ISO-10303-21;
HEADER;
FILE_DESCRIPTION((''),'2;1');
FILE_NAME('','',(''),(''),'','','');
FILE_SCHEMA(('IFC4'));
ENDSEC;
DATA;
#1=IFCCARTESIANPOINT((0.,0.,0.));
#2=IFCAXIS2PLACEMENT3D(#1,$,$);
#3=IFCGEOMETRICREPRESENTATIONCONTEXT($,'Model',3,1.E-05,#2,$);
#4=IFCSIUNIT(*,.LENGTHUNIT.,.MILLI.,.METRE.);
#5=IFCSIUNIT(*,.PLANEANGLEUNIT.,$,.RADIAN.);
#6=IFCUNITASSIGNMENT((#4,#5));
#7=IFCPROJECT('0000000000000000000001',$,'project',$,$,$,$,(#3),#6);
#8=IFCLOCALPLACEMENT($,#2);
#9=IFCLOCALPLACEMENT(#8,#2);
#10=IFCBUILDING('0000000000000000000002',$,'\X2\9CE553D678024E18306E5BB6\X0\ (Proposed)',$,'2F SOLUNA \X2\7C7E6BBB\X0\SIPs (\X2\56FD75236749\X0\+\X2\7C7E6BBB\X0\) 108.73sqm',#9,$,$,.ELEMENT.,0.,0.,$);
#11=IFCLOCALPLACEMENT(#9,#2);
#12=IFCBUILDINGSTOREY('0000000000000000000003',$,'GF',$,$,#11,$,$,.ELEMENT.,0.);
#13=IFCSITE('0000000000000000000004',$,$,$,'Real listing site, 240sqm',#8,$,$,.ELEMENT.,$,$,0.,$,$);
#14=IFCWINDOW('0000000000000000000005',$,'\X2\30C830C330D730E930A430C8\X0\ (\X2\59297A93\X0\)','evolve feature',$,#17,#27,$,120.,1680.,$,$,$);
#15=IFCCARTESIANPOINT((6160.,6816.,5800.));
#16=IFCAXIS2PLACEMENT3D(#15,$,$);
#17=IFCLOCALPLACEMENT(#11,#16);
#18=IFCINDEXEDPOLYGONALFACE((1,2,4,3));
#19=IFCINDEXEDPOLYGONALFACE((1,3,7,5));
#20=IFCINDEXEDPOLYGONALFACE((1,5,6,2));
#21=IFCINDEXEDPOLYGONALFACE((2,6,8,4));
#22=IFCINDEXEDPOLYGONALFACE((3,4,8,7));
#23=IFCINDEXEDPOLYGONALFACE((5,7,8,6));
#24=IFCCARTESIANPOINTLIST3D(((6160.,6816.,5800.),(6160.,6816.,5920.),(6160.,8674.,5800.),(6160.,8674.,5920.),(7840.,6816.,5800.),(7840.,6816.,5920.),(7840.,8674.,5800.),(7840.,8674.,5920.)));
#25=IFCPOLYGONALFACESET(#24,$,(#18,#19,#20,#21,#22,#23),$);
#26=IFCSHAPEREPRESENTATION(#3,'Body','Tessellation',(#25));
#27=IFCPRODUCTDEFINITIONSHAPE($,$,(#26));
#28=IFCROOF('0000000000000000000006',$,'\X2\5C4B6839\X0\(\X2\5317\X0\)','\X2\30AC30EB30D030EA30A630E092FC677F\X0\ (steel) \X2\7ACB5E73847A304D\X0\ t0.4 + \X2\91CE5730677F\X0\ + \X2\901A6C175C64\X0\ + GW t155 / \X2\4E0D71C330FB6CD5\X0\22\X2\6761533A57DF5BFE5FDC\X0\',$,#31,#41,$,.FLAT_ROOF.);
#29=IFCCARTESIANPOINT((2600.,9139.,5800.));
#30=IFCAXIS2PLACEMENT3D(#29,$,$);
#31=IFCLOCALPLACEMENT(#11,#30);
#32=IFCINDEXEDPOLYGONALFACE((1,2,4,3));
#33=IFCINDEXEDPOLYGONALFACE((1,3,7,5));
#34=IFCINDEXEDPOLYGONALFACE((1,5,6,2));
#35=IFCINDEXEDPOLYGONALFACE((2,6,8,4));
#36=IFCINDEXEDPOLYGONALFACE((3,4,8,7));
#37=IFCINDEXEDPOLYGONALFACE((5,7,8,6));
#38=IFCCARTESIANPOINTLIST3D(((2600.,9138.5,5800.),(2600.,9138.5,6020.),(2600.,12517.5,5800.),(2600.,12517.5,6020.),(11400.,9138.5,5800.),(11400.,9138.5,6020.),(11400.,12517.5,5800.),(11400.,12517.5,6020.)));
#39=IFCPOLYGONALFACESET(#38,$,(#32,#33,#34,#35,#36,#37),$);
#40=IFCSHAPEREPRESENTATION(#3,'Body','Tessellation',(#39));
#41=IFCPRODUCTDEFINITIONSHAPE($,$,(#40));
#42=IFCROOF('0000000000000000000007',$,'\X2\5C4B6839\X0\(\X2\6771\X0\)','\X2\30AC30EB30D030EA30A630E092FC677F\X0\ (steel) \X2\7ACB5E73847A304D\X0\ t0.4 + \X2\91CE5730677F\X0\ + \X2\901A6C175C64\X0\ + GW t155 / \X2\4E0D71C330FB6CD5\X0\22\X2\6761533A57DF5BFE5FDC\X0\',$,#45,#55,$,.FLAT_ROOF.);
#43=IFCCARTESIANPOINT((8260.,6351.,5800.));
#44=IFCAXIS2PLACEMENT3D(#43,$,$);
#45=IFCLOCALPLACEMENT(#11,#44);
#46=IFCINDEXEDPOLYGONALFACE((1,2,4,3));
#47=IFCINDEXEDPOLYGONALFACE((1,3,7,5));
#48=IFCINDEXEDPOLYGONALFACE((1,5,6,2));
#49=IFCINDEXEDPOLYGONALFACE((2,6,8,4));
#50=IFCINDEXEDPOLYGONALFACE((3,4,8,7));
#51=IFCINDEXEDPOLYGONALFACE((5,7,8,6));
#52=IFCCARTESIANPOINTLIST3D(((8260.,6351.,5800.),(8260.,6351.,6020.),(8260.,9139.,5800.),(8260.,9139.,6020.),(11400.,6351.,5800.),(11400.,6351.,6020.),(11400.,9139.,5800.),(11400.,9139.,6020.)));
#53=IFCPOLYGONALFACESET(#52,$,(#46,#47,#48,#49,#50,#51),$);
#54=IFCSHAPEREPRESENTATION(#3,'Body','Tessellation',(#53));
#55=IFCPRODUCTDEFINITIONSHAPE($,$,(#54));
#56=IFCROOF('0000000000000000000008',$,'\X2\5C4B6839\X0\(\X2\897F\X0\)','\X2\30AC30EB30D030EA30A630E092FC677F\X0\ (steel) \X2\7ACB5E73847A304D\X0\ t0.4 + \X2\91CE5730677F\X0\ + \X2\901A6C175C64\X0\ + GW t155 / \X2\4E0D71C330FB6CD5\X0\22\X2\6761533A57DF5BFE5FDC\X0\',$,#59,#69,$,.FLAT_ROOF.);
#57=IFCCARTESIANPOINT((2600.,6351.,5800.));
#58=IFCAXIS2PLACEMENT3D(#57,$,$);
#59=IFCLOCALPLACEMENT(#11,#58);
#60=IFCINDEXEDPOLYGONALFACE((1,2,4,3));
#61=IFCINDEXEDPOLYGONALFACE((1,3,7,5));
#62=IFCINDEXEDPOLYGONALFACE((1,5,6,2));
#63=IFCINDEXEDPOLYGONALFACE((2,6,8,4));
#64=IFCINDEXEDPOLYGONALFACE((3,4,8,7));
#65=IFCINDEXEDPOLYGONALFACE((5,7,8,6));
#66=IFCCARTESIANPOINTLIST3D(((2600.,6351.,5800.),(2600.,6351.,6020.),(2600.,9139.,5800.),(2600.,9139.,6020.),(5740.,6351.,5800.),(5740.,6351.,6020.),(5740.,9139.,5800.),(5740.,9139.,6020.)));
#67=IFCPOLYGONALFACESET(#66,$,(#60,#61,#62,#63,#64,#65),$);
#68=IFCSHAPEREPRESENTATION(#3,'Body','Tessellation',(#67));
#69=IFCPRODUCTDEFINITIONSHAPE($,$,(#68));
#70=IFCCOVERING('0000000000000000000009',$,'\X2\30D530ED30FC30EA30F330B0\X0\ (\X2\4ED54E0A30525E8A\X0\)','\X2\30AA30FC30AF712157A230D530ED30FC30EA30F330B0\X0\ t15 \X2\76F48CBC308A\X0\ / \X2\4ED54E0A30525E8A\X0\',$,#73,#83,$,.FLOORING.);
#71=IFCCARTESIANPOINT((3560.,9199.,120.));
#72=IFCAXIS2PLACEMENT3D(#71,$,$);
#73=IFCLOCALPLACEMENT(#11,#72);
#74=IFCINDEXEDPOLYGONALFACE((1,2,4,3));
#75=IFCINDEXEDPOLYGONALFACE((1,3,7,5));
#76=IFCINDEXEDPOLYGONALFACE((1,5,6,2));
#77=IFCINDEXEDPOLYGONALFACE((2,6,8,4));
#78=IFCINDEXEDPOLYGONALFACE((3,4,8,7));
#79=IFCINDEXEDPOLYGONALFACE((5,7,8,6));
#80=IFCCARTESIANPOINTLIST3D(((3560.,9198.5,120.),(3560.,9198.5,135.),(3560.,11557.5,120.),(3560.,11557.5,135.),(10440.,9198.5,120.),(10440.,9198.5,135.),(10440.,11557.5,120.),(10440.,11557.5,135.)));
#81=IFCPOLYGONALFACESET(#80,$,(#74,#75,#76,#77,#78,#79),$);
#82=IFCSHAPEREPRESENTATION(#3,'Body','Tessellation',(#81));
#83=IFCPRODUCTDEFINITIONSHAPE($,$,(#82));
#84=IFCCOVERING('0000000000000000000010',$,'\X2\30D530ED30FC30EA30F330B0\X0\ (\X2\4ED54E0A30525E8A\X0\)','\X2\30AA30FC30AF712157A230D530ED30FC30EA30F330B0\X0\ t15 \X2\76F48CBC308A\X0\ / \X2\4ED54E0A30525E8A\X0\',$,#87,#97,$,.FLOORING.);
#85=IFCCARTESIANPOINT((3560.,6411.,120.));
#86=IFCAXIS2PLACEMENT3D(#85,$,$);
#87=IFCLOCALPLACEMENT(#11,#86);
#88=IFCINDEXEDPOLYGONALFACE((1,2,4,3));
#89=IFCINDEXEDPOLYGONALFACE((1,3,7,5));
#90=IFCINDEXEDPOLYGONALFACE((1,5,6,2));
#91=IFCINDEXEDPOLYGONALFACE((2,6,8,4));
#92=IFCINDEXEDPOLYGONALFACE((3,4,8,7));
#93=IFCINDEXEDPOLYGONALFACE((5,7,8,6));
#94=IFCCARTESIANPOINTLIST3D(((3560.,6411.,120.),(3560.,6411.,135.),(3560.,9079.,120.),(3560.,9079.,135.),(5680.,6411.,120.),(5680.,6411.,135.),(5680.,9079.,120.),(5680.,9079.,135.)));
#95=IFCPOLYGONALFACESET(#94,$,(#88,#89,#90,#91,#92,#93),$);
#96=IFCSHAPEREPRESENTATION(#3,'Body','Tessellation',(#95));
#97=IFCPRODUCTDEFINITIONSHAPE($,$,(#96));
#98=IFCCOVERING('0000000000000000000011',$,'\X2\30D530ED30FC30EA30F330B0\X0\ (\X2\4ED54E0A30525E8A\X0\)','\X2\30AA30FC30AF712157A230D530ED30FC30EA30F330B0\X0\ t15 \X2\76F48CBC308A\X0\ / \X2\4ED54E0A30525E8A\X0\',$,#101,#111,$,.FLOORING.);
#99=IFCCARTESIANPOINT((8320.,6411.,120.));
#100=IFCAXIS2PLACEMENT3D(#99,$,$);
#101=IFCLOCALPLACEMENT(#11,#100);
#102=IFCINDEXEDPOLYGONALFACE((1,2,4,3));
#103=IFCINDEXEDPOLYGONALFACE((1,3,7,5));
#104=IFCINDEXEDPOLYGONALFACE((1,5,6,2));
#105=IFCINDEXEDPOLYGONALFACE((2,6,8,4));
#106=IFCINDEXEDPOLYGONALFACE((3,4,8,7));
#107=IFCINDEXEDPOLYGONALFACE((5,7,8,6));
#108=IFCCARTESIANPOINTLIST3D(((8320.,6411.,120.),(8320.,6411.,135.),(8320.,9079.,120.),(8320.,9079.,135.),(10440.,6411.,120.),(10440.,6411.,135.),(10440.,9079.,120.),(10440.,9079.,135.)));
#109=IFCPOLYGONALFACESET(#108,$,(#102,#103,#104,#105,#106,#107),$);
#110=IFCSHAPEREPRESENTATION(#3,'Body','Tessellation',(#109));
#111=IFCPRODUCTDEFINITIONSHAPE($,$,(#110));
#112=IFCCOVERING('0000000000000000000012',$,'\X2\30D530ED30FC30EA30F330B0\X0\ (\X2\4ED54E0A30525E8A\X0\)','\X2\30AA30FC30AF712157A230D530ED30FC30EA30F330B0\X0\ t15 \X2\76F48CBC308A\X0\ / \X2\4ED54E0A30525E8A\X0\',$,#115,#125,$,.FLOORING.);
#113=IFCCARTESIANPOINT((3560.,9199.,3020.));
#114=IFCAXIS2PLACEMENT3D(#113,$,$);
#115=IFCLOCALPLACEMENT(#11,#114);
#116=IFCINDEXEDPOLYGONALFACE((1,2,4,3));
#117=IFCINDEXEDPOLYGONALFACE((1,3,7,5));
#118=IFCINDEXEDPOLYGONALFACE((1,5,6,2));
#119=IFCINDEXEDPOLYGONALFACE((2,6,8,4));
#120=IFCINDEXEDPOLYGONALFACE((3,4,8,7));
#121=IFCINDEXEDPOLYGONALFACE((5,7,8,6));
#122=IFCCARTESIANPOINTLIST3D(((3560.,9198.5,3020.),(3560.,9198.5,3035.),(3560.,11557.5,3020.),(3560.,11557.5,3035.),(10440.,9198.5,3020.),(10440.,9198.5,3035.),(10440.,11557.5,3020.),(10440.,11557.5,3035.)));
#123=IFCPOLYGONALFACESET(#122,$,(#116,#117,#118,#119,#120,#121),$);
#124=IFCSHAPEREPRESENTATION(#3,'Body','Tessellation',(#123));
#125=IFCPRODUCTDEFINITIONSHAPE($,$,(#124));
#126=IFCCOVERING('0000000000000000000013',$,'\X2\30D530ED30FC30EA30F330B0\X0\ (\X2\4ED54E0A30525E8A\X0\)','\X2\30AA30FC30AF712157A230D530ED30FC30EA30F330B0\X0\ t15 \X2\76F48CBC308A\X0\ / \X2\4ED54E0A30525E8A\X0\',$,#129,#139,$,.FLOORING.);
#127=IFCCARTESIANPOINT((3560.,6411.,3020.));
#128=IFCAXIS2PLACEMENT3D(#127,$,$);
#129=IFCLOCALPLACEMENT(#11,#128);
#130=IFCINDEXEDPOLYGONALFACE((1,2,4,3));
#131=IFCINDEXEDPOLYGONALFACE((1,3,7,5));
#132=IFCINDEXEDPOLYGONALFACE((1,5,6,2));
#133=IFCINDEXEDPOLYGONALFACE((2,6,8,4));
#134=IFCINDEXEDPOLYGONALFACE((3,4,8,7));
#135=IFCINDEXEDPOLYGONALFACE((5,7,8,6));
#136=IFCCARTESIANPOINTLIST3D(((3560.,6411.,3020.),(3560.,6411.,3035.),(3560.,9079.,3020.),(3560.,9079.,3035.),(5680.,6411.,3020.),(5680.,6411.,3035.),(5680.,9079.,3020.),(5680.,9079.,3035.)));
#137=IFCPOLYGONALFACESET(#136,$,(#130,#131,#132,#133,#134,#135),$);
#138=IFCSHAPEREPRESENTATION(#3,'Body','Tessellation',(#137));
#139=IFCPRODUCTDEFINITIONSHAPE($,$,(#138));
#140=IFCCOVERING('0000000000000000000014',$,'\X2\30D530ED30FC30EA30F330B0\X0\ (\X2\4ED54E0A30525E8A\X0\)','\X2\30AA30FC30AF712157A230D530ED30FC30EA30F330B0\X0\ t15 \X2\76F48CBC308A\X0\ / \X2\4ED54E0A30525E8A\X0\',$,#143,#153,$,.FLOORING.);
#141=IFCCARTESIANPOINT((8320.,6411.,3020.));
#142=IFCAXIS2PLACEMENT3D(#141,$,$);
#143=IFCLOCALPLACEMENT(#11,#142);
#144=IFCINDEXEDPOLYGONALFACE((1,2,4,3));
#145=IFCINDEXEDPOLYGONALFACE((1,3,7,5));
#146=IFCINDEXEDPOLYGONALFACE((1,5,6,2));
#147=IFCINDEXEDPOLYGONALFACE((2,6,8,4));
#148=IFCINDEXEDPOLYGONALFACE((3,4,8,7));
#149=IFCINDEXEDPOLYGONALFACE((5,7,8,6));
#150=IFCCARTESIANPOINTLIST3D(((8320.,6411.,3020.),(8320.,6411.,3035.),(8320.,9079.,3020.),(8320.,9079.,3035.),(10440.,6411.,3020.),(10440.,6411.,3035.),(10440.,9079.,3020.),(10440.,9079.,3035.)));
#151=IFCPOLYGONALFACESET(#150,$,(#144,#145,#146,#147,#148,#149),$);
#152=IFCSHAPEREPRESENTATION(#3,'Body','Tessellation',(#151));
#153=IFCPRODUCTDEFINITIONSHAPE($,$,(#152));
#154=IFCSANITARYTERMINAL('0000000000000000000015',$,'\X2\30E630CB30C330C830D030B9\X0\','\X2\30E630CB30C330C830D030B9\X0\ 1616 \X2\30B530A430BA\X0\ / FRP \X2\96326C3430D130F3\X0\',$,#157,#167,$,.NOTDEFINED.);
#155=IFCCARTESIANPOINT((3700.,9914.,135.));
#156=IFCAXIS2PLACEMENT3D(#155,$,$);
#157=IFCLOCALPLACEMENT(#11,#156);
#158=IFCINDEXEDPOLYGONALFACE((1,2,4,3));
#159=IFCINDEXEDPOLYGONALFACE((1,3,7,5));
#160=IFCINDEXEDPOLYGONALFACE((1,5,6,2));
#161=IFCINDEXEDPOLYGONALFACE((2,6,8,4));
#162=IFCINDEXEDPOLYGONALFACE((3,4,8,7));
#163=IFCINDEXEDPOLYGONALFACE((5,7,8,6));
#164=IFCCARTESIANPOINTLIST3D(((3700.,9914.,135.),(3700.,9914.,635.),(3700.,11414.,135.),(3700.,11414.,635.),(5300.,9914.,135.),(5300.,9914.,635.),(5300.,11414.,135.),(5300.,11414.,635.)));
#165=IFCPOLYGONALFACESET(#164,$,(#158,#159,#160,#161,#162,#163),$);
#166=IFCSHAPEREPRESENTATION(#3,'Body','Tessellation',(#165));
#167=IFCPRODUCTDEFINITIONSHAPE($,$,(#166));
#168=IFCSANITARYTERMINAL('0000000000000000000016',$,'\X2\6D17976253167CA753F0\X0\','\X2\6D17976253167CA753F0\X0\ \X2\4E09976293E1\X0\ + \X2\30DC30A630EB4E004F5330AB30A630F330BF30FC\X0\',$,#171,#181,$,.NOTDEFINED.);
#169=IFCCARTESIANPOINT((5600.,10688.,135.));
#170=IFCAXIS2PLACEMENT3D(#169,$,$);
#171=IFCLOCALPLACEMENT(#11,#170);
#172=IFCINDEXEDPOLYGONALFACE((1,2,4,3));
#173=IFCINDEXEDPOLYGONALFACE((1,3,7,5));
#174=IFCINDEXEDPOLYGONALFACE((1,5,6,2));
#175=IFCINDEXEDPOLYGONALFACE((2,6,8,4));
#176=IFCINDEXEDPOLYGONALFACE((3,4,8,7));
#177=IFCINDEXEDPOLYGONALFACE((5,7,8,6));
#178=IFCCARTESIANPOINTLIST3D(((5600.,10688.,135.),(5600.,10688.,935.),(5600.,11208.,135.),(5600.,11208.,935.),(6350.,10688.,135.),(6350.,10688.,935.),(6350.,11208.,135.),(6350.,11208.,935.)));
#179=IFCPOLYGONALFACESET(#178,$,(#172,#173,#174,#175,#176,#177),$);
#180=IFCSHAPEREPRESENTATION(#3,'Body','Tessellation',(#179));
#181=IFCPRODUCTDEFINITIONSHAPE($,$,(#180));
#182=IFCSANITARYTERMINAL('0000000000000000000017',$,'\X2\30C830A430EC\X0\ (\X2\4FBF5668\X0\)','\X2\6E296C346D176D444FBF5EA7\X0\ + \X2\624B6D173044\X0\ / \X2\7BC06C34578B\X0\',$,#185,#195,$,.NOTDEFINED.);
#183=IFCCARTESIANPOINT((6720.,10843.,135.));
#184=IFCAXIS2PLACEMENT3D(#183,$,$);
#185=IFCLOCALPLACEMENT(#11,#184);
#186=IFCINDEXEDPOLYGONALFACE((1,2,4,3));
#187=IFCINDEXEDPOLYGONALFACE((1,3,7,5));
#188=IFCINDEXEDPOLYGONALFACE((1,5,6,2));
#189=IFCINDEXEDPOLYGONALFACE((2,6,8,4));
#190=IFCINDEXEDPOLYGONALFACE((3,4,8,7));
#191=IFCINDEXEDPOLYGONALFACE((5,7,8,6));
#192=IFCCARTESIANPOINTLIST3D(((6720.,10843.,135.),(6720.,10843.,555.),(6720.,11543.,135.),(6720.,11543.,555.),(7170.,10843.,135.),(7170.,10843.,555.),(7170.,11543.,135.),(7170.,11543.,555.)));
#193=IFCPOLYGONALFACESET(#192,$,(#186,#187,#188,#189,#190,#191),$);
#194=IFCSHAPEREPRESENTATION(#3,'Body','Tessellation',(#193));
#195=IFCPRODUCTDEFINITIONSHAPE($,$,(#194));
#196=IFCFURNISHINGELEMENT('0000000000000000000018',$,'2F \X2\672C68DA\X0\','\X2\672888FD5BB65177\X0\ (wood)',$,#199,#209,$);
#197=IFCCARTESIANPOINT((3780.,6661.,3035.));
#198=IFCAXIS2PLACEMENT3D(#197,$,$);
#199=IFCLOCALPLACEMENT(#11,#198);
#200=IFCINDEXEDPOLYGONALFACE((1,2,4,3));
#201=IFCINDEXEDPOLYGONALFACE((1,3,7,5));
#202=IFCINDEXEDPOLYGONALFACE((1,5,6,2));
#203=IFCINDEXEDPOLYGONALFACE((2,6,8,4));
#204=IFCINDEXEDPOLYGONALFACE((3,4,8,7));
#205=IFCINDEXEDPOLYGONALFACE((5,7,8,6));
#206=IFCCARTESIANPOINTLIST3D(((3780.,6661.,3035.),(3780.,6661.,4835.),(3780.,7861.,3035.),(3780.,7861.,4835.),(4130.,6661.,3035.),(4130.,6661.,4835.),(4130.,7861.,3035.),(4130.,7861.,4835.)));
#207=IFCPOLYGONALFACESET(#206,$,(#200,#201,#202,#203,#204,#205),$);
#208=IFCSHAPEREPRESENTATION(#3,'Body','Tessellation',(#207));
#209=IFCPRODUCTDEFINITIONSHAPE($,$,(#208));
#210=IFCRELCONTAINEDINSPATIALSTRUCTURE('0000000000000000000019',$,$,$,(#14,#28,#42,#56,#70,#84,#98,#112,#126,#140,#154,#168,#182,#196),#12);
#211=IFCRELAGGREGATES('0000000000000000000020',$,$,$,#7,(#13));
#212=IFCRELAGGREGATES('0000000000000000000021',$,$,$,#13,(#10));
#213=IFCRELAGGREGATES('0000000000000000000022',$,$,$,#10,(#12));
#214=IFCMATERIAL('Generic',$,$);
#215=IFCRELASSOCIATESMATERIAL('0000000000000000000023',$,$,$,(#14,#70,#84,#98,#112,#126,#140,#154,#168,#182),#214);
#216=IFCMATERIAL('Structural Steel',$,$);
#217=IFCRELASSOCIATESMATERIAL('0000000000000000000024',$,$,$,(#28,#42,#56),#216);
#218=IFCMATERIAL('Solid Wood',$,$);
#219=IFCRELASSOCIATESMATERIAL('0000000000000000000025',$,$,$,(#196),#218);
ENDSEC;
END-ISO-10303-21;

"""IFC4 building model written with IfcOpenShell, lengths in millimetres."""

from ifc_helpers import new_model, si_unit, frame, frame_2d, origin, place, context, project, spatial, rectangle, extrude, material, element, save


model = new_model("IFC4")

# Units and contexts
model_context = context("Model", 3, precision=1e-05, world=origin())
ifc_project = project(units=[si_unit("LENGTHUNIT", "METRE", prefix="MILLI"), si_unit("PLANEANGLEUNIT", "RADIAN")], contexts=[model_context])

# Site, building, storey
site_placement = place(None, origin())
site = spatial("IfcSite", under=ifc_project, at=site_placement, ObjectType="Real listing site, 240sqm", CompositionType="ELEMENT", RefElevation=0.0)
building_placement = place(site_placement, origin())
building = spatial("IfcBuilding", under=site, at=building_placement, Name="鳥取砂丘の家 (Proposed)", ObjectType="2F SOLUNA 籾殻SIPs (国産杉+籾殻) 108.73sqm", CompositionType="ELEMENT", ElevationOfRefHeight=0.0, ElevationOfTerrain=0.0)
storey_placement = place(building_placement, origin())
storey = spatial("IfcBuildingStorey", under=building, at=storey_placement, Name="GF", CompositionType="ELEMENT", Elevation=0.0)

# Shared definitions
ifc_material_1 = material(Name="Solid Wood")

# Window
ifc_material_2 = material(Name="Generic")
window_1_placement = place(storey_placement, frame((6160.0, 6816.0, 5800.0)))
element("IfcWindow", 1, at=window_1_placement, inside=storey, material=ifc_material_2, Name="トップライト (天窓)", Description="evolve feature", OverallHeight=120.0, OverallWidth=1680.0, context=model_context, shape_type="SweptSolid", body=[
    extrude(rectangle(XDim=1680.0, YDim=1858.0, at=frame_2d((840.0, 929.0))), frame((6160.0, 6816.0, 5800.0)), (0.0, 0.0, 1.0), 120.0),
])

# Roofs
ifc_material_3 = material(Name="Structural Steel")
roof_1_placement = place(storey_placement, frame((2600.0, 9139.0, 5800.0)))
element("IfcRoof", 2, at=roof_1_placement, inside=storey, material=ifc_material_3, Name="屋根(北)", Description="ガルバリウム鋼板 (steel) 立平葺き t0.4 + 野地板 + 通気層 + GW t155 / 不燃・法22条区域対応", PredefinedType="FLAT_ROOF", context=model_context, shape_type="SweptSolid", body=[
    extrude(rectangle(XDim=8800.0, YDim=3379.0, at=frame_2d((4400.0, 1689.0))), frame((2600.0, 9139.0, 5800.0)), (0.0, 0.0, 1.0), 220.0),
])
roof_2_placement = place(storey_placement, frame((8260.0, 6351.0, 5800.0)))
element("IfcRoof", 3, at=roof_2_placement, inside=storey, material=ifc_material_3, Name="屋根(東)", Description="ガルバリウム鋼板 (steel) 立平葺き t0.4 + 野地板 + 通気層 + GW t155 / 不燃・法22条区域対応", PredefinedType="FLAT_ROOF", context=model_context, shape_type="SweptSolid", body=[
    extrude(rectangle(XDim=3140.0, YDim=2788.0, at=frame_2d((1570.0, 1394.0))), frame((8260.0, 6351.0, 5800.0)), (0.0, 0.0, 1.0), 220.0),
])
roof_3_placement = place(storey_placement, frame((2600.0, 6351.0, 5800.0)))
element("IfcRoof", 4, at=roof_3_placement, inside=storey, material=ifc_material_3, Name="屋根(西)", Description="ガルバリウム鋼板 (steel) 立平葺き t0.4 + 野地板 + 通気層 + GW t155 / 不燃・法22条区域対応", PredefinedType="FLAT_ROOF", context=model_context, shape_type="SweptSolid", body=[
    extrude(rectangle(XDim=3140.0, YDim=2788.0, at=frame_2d((1570.0, 1394.0))), frame((2600.0, 6351.0, 5800.0)), (0.0, 0.0, 1.0), 220.0),
])

# Coverings
covering_1_placement = place(storey_placement, frame((3560.0, 9199.0, 120.0)))
element("IfcCovering", 5, at=covering_1_placement, inside=storey, material=ifc_material_2, Name="フローリング (仕上げ床)", Description="オーク無垢フローリング t15 直貼り / 仕上げ床", PredefinedType="FLOORING", context=model_context, shape_type="SweptSolid", body=[
    extrude(rectangle(XDim=6880.0, YDim=2359.0, at=frame_2d((3440.0, 1179.0))), frame((3560.0, 9199.0, 120.0)), (0.0, 0.0, 1.0), 15.0),
])
covering_2_placement = place(storey_placement, frame((3560.0, 6411.0, 120.0)))
element("IfcCovering", 6, at=covering_2_placement, inside=storey, material=ifc_material_2, Name="フローリング (仕上げ床)", Description="オーク無垢フローリング t15 直貼り / 仕上げ床", PredefinedType="FLOORING", context=model_context, shape_type="SweptSolid", body=[
    extrude(rectangle(XDim=2120.0, YDim=2668.0, at=frame_2d((1060.0, 1334.0))), frame((3560.0, 6411.0, 120.0)), (0.0, 0.0, 1.0), 15.0),
])
covering_3_placement = place(storey_placement, frame((8320.0, 6411.0, 120.0)))
element("IfcCovering", 7, at=covering_3_placement, inside=storey, material=ifc_material_2, Name="フローリング (仕上げ床)", Description="オーク無垢フローリング t15 直貼り / 仕上げ床", PredefinedType="FLOORING", context=model_context, shape_type="SweptSolid", body=[
    extrude(rectangle(XDim=2120.0, YDim=2668.0, at=frame_2d((1060.0, 1334.0))), frame((8320.0, 6411.0, 120.0)), (0.0, 0.0, 1.0), 15.0),
])
covering_4_placement = place(storey_placement, frame((3560.0, 9199.0, 3020.0)))
element("IfcCovering", 8, at=covering_4_placement, inside=storey, material=ifc_material_2, Name="フローリング (仕上げ床)", Description="オーク無垢フローリング t15 直貼り / 仕上げ床", PredefinedType="FLOORING", context=model_context, shape_type="SweptSolid", body=[
    extrude(rectangle(XDim=6880.0, YDim=2359.0, at=frame_2d((3440.0, 1179.0))), frame((3560.0, 9199.0, 3020.0)), (0.0, 0.0, 1.0), 15.0),
])
covering_5_placement = place(storey_placement, frame((3560.0, 6411.0, 3020.0)))
element("IfcCovering", 9, at=covering_5_placement, inside=storey, material=ifc_material_2, Name="フローリング (仕上げ床)", Description="オーク無垢フローリング t15 直貼り / 仕上げ床", PredefinedType="FLOORING", context=model_context, shape_type="SweptSolid", body=[
    extrude(rectangle(XDim=2120.0, YDim=2668.0, at=frame_2d((1060.0, 1334.0))), frame((3560.0, 6411.0, 3020.0)), (0.0, 0.0, 1.0), 15.0),
])
covering_6_placement = place(storey_placement, frame((8320.0, 6411.0, 3020.0)))
element("IfcCovering", 10, at=covering_6_placement, inside=storey, material=ifc_material_2, Name="フローリング (仕上げ床)", Description="オーク無垢フローリング t15 直貼り / 仕上げ床", PredefinedType="FLOORING", context=model_context, shape_type="SweptSolid", body=[
    extrude(rectangle(XDim=2120.0, YDim=2668.0, at=frame_2d((1060.0, 1334.0))), frame((8320.0, 6411.0, 3020.0)), (0.0, 0.0, 1.0), 15.0),
])

# Sanitary terminals
sanitary_terminal_1_placement = place(storey_placement, frame((3700.0, 9914.0, 135.0)))
element("IfcSanitaryTerminal", 11, at=sanitary_terminal_1_placement, inside=storey, material=ifc_material_2, Name="ユニットバス", Description="ユニットバス 1616 サイズ / FRP 防水パン", PredefinedType="NOTDEFINED", context=model_context, shape_type="SweptSolid", body=[
    extrude(rectangle(XDim=1600.0, YDim=1500.0, at=frame_2d((800.0, 750.0))), frame((3700.0, 9914.0, 135.0)), (0.0, 0.0, 1.0), 500.0),
])
sanitary_terminal_2_placement = place(storey_placement, frame((5600.0, 10688.0, 135.0)))
element("IfcSanitaryTerminal", 12, at=sanitary_terminal_2_placement, inside=storey, material=ifc_material_2, Name="洗面化粧台", Description="洗面化粧台 三面鏡 + ボウル一体カウンター", PredefinedType="NOTDEFINED", context=model_context, shape_type="SweptSolid", body=[
    extrude(rectangle(XDim=750.0, YDim=520.0, at=frame_2d((375.0, 260.0))), frame((5600.0, 10688.0, 135.0)), (0.0, 0.0, 1.0), 800.0),
])
sanitary_terminal_3_placement = place(storey_placement, frame((6720.0, 10843.0, 135.0)))
element("IfcSanitaryTerminal", 13, at=sanitary_terminal_3_placement, inside=storey, material=ifc_material_2, Name="トイレ (便器)", Description="温水洗浄便座 + 手洗い / 節水型", PredefinedType="NOTDEFINED", context=model_context, shape_type="SweptSolid", body=[
    extrude(rectangle(XDim=450.0, YDim=700.0, at=frame_2d((225.0, 350.0))), frame((6720.0, 10843.0, 135.0)), (0.0, 0.0, 1.0), 420.0),
])

# Furnishing element
furnishing_placement = place(storey_placement, frame((3780.0, 6661.0, 3035.0)))
element("IfcFurnishingElement", 14, at=furnishing_placement, inside=storey, material=ifc_material_1, Name="2F 本棚", Description="木製家具 (wood)", context=model_context, shape_type="SweptSolid", body=[
    extrude(rectangle(XDim=350.0, YDim=1200.0, at=frame_2d((175.0, 600.0))), frame((3780.0, 6661.0, 3035.0)), (0.0, 0.0, 1.0), 1800.0),
])

save(model, "model.ifc")
